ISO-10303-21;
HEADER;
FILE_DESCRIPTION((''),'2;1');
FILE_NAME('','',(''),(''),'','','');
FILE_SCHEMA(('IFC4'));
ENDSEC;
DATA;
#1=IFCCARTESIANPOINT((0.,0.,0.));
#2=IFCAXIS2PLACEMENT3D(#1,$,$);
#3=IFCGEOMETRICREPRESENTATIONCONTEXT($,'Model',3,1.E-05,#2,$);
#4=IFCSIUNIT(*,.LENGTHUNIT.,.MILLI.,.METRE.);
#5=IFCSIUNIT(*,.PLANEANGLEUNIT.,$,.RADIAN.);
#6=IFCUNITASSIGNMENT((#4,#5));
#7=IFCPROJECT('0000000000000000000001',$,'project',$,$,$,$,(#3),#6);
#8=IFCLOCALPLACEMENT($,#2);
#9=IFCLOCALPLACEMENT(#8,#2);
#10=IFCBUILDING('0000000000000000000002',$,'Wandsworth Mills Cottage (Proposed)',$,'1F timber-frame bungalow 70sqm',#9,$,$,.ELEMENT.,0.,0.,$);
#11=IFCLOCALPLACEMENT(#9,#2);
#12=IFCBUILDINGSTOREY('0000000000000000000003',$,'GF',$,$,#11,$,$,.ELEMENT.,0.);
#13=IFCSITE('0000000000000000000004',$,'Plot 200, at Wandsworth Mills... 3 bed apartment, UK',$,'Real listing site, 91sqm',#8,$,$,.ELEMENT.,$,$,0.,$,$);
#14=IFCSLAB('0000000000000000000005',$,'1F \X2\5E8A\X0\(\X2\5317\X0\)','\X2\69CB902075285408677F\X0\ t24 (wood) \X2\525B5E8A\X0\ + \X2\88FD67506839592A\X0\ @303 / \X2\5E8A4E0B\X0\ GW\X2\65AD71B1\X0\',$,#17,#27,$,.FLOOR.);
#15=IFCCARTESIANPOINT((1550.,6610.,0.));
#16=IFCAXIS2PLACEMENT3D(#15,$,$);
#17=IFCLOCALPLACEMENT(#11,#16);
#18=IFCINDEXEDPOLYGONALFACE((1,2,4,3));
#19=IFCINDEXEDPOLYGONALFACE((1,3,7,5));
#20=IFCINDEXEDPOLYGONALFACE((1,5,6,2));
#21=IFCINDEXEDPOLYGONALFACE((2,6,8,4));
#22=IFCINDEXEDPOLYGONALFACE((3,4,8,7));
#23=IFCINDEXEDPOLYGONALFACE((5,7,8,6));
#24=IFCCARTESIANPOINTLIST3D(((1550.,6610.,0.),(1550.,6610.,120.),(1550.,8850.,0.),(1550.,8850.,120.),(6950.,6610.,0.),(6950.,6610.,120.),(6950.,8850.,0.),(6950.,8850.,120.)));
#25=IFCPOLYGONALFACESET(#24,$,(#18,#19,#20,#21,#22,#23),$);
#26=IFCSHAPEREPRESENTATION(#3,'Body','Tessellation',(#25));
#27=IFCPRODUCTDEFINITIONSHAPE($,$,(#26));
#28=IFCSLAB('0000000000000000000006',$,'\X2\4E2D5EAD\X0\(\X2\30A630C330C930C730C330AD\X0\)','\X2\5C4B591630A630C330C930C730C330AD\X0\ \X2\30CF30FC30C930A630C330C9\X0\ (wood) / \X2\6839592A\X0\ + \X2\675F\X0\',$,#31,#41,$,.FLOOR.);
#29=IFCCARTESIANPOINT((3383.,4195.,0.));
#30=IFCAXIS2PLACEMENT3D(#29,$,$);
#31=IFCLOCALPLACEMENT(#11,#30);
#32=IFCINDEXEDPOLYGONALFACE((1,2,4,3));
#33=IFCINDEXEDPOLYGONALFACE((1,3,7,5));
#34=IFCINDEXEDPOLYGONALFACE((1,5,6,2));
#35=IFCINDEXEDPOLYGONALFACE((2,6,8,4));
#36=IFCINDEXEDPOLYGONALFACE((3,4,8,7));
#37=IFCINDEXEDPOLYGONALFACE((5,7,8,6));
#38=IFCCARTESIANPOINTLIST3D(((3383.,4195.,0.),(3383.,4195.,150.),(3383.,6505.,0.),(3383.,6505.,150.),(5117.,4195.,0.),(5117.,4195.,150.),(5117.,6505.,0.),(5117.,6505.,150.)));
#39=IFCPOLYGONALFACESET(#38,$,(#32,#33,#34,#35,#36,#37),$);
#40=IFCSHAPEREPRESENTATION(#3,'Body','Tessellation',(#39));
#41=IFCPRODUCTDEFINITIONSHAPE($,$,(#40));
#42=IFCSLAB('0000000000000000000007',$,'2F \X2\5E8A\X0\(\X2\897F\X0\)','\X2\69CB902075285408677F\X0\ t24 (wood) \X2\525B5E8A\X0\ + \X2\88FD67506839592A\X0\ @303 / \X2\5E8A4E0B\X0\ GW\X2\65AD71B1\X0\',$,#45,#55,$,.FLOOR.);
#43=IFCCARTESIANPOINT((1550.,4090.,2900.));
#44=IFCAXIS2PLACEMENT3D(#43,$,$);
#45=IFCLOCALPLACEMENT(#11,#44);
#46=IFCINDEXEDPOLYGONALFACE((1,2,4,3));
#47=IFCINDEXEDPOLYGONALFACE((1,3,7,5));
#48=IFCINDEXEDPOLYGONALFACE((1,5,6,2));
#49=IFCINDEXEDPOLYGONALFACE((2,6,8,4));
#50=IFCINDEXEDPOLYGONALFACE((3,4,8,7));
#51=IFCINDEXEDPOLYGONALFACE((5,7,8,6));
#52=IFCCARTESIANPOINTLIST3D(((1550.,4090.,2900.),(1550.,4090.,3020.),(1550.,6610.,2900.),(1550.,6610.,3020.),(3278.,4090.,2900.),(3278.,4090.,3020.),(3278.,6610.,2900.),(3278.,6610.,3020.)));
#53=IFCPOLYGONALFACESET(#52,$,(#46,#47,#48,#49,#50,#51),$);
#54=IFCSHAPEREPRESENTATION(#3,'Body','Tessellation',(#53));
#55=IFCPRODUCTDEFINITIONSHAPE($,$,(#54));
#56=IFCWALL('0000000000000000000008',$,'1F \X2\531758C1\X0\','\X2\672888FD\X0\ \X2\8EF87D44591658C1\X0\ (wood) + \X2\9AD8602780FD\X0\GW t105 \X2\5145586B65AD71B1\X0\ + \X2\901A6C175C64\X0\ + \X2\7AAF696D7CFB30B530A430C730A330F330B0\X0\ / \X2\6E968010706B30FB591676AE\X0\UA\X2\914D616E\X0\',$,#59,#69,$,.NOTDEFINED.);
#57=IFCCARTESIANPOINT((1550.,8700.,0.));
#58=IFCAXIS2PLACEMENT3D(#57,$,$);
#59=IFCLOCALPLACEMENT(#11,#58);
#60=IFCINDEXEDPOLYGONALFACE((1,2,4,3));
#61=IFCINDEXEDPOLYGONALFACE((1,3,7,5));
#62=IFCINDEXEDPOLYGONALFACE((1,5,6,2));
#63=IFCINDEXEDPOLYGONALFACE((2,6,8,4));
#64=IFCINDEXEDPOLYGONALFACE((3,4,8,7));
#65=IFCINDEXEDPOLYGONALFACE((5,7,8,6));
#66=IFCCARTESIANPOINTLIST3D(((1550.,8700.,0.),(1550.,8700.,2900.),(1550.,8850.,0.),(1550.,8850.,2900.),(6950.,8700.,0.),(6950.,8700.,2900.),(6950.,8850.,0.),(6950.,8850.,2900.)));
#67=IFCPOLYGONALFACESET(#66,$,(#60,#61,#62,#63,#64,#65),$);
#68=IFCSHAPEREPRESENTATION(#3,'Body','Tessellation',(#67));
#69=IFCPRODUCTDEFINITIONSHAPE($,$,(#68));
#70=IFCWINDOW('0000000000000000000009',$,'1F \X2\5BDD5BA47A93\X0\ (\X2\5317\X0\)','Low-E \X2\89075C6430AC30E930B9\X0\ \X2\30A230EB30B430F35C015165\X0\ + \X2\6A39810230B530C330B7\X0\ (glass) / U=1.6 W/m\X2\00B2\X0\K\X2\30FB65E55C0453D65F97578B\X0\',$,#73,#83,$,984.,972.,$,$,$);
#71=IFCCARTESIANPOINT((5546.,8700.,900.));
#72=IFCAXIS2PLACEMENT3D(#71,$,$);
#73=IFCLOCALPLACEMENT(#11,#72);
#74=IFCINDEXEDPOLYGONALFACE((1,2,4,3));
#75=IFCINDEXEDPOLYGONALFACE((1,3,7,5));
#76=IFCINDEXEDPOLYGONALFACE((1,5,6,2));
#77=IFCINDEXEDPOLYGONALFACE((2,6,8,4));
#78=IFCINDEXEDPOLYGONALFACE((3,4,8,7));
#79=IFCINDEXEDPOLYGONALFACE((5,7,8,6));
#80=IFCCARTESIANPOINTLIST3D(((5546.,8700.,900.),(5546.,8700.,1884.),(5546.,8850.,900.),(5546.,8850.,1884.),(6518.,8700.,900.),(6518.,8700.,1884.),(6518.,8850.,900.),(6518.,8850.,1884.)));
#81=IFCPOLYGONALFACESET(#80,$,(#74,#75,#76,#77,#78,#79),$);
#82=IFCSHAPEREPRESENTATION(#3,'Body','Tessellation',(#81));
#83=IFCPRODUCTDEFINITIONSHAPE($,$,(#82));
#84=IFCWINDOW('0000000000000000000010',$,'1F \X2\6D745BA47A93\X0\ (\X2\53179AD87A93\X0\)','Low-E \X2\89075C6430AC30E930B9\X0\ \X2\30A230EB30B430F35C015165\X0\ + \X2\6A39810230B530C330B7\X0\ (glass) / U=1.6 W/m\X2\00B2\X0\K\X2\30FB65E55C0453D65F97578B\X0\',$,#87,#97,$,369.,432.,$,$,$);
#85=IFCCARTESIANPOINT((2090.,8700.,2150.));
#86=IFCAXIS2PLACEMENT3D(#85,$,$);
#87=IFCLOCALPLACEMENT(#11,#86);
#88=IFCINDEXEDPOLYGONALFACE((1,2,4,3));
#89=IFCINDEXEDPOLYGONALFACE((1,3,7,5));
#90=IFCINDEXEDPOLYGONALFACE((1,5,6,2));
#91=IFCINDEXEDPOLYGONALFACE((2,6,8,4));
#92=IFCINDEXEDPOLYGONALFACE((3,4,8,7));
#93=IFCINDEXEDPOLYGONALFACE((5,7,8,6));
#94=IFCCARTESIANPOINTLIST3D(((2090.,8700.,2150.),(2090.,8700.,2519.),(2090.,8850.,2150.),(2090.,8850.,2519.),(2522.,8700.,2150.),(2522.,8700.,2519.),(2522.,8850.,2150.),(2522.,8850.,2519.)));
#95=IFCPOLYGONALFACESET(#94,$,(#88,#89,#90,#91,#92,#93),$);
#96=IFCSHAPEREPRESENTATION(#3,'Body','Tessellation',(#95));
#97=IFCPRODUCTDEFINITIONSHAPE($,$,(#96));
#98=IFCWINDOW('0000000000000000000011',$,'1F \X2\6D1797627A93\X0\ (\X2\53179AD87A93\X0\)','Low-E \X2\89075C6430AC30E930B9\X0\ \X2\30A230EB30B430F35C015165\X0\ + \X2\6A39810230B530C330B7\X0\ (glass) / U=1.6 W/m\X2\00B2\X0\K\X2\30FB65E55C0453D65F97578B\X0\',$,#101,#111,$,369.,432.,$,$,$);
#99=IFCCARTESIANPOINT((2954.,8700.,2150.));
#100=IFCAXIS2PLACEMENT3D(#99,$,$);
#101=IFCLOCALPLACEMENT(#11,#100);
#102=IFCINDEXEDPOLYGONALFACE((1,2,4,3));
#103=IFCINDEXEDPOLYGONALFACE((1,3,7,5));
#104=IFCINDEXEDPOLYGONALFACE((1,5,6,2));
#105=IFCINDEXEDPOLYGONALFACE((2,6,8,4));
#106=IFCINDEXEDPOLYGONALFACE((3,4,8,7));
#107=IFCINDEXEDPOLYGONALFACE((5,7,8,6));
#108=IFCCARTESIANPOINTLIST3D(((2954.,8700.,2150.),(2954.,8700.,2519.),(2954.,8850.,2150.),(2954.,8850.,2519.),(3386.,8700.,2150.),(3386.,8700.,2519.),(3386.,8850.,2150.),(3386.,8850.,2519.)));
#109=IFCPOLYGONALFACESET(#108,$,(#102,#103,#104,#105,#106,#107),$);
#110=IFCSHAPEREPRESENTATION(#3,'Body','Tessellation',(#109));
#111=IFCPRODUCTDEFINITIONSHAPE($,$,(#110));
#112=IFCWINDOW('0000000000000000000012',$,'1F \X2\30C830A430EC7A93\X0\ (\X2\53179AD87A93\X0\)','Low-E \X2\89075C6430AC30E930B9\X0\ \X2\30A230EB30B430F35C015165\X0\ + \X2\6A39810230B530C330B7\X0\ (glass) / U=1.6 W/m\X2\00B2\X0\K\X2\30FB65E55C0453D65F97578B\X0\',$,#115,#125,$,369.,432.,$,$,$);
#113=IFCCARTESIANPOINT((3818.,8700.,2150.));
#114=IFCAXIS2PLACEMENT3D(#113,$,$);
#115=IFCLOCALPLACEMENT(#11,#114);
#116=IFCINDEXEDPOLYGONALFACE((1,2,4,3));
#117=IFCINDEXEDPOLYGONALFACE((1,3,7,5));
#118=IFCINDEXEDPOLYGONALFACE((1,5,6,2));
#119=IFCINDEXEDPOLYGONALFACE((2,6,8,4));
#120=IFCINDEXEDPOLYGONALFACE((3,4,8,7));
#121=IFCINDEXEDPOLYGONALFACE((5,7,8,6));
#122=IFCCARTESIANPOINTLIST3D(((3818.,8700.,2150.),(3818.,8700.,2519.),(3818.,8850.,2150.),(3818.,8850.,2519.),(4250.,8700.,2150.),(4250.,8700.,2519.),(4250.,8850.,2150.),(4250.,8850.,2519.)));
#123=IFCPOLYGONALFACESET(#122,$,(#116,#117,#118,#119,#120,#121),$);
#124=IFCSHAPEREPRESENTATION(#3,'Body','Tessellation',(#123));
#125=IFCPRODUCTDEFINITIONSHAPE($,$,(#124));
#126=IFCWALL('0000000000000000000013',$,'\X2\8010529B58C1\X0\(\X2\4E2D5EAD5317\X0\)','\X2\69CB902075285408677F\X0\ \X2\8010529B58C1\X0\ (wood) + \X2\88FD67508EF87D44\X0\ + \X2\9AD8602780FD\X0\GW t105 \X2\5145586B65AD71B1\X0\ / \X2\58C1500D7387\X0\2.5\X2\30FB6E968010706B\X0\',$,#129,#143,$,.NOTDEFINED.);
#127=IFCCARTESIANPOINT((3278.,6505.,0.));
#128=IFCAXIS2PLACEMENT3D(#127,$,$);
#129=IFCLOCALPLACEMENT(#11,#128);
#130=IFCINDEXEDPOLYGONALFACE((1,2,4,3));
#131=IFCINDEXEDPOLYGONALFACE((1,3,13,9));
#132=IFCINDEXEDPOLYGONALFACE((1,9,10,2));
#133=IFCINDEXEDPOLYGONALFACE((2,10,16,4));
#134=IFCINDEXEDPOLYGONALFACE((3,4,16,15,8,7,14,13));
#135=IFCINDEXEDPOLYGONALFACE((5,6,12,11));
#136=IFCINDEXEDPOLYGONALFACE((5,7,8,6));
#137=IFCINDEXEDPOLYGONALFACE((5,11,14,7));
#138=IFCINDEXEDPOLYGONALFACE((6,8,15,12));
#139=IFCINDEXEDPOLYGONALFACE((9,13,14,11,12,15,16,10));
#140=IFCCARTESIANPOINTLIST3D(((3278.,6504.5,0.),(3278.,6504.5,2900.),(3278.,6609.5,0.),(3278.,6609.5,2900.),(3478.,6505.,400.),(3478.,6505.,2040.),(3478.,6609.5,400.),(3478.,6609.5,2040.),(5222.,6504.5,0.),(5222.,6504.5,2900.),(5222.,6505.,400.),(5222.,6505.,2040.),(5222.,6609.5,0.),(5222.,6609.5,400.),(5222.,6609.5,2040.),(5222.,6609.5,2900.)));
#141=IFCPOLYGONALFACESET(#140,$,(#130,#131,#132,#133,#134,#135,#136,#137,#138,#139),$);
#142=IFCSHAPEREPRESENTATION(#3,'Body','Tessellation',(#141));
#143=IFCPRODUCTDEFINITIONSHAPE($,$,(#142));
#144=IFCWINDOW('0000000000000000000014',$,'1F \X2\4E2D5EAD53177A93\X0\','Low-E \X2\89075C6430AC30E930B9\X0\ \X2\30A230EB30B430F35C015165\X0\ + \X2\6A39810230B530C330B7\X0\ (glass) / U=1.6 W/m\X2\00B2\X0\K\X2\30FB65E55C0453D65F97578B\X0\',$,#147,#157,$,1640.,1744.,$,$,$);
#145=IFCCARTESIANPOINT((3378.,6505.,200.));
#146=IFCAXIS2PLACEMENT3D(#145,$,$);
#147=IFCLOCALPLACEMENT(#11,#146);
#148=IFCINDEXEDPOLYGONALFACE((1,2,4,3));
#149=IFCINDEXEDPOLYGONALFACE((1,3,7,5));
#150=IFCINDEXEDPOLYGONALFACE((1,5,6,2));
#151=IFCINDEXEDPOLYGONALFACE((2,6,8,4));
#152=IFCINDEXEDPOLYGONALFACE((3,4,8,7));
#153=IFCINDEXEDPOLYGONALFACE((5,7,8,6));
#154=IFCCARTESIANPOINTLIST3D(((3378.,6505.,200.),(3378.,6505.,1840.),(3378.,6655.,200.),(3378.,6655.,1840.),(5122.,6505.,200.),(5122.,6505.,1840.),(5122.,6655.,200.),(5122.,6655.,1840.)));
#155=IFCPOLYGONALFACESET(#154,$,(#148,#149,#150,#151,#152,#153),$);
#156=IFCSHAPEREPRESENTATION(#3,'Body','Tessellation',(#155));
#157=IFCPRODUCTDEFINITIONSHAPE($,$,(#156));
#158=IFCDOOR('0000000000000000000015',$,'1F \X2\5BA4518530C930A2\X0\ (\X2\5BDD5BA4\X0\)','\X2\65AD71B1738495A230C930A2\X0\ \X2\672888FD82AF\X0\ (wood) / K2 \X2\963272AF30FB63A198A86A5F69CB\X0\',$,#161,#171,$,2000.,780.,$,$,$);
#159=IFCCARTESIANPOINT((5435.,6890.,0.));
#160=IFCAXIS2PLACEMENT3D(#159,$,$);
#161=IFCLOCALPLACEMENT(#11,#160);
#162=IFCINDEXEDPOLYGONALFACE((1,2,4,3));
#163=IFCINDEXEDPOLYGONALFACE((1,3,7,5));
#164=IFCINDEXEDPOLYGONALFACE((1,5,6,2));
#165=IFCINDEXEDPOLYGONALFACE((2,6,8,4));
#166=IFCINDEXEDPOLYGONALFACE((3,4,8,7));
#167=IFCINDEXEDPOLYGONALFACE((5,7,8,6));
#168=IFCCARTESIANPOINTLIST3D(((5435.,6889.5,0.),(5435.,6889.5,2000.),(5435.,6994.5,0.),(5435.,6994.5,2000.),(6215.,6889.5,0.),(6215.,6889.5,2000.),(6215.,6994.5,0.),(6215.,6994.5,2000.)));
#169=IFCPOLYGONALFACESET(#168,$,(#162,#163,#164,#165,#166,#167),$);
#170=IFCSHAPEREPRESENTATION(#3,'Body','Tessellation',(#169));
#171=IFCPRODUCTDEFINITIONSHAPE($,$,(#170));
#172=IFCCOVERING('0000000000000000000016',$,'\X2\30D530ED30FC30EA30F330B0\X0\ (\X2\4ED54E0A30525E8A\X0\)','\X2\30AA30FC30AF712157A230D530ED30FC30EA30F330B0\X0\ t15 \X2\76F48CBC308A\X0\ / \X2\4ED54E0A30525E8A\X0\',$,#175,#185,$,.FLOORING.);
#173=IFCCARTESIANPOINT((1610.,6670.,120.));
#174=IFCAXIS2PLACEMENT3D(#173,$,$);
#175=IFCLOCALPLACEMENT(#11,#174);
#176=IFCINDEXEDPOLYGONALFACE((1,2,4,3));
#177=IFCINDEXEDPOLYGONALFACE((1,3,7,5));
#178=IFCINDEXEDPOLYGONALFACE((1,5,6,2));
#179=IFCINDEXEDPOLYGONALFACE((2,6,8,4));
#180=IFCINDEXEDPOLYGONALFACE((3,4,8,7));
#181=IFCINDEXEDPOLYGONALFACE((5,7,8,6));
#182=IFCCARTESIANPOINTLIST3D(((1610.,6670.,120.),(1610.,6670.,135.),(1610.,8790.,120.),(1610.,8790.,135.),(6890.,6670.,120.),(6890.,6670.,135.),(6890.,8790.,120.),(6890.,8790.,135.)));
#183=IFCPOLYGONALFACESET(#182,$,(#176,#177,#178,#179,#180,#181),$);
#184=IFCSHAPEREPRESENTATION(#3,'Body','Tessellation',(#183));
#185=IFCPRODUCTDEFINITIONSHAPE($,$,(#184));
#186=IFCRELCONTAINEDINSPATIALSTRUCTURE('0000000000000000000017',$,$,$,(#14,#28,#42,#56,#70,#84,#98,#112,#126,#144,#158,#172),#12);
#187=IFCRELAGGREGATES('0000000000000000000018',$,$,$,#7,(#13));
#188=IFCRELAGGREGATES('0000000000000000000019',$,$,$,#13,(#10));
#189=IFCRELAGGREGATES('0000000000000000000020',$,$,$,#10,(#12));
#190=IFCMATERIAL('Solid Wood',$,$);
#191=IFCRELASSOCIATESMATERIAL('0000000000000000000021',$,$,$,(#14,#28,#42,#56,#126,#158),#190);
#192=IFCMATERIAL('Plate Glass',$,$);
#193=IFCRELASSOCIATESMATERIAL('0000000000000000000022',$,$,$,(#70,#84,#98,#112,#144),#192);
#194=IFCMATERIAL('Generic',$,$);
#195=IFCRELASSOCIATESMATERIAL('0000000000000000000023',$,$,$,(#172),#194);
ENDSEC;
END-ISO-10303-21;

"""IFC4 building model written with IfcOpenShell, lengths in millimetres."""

from ifc_helpers import new_model, si_unit, frame, frame_2d, origin, place, context, project, spatial, rectangle, extrude, material, element, fill, save


model = new_model("IFC4")

# Units and contexts
model_context = context("Model", 3, precision=1e-05, world=origin())
ifc_project = project(units=[si_unit("LENGTHUNIT", "METRE", prefix="MILLI"), si_unit("PLANEANGLEUNIT", "RADIAN")], contexts=[model_context])

# Site, building, storey
site_placement = place(None, origin())
site = spatial("IfcSite", under=ifc_project, at=site_placement, Name="Plot 200, at Wandsworth Mills... 3 bed apartment, UK", ObjectType="Real listing site, 91sqm", CompositionType="ELEMENT", RefElevation=0.0)
building_placement = place(site_placement, origin())
building = spatial("IfcBuilding", under=site, at=building_placement, Name="Wandsworth Mills Cottage (Proposed)", ObjectType="1F timber-frame bungalow 70sqm", CompositionType="ELEMENT", ElevationOfRefHeight=0.0, ElevationOfTerrain=0.0)
storey_placement = place(building_placement, origin())
storey = spatial("IfcBuildingStorey", under=building, at=storey_placement, Name="GF", CompositionType="ELEMENT", Elevation=0.0)

# Slabs
ifc_material_1 = material(Name="Solid Wood")
slab_1_placement = place(storey_placement, frame((1550.0, 6610.0, 0.0)))
element("IfcSlab", 1, at=slab_1_placement, inside=storey, material=ifc_material_1, Name="1F 床(北)", Description="構造用合板 t24 (wood) 剛床 + 製材根太 @303 / 床下 GW断熱", PredefinedType="FLOOR", context=model_context, shape_type="SweptSolid", body=[
    extrude(rectangle(XDim=5400.0, YDim=2240.0, at=frame_2d((2700.0, 1120.0))), frame((1550.0, 6610.0, 0.0)), (0.0, 0.0, 1.0), 120.0),
])
slab_2_placement = place(storey_placement, frame((3383.0, 4195.0, 0.0)))
element("IfcSlab", 2, at=slab_2_placement, inside=storey, material=ifc_material_1, Name="中庭(ウッドデッキ)", Description="屋外ウッドデッキ ハードウッド (wood) / 根太 + 束", PredefinedType="FLOOR", context=model_context, shape_type="SweptSolid", body=[
    extrude(rectangle(XDim=1734.0, YDim=2310.0, at=frame_2d((867.0, 1155.0))), frame((3383.0, 4195.0, 0.0)), (0.0, 0.0, 1.0), 150.0),
])
slab_3_placement = place(storey_placement, frame((1550.0, 4090.0, 2900.0)))
element("IfcSlab", 3, at=slab_3_placement, inside=storey, material=ifc_material_1, Name="2F 床(西)", Description="構造用合板 t24 (wood) 剛床 + 製材根太 @303 / 床下 GW断熱", PredefinedType="FLOOR", context=model_context, shape_type="SweptSolid", body=[
    extrude(rectangle(XDim=1728.0, YDim=2520.0, at=frame_2d((864.0, 1260.0))), frame((1550.0, 4090.0, 2900.0)), (0.0, 0.0, 1.0), 120.0),
])

# Wall, openings, windows
wall_1_placement = place(storey_placement, frame((1550.0, 8700.0, 0.0)))
wall_1 = element("IfcWall", 4, at=wall_1_placement, inside=storey, material=ifc_material_1, Name="1F 北壁", Description="木製 軸組外壁 (wood) + 高性能GW t105 充填断熱 + 通気層 + 窯業系サイディング / 準耐火・外皮UA配慮", PredefinedType="NOTDEFINED", context=model_context, shape_type="SweptSolid", body=[
    extrude(rectangle(XDim=5400.0, YDim=150.0, at=frame_2d((2700.0, 75.0))), frame((1550.0, 8700.0, 0.0)), (0.0, 0.0, 1.0), 2900.0),
])
opening_1_placement = place(storey_placement, frame((5546.0, 8700.0, 900.0)))
opening_1 = element("IfcOpeningElement", 5, at=opening_1_placement, cuts=wall_1, PredefinedType="NOTDEFINED", context=model_context, shape_type="SweptSolid", body=[
    extrude(rectangle(XDim=972.0, YDim=150.0, at=frame_2d((486.0, 75.0))), frame((5546.0, 8700.0, 900.0)), (0.0, 0.0, 1.0), 984.0),
])
opening_2_placement = place(storey_placement, frame((2090.0, 8700.0, 2150.0)))
opening_2 = element("IfcOpeningElement", 6, at=opening_2_placement, cuts=wall_1, PredefinedType="NOTDEFINED", context=model_context, shape_type="SweptSolid", body=[
    extrude(rectangle(XDim=432.0, YDim=150.0, at=frame_2d((216.0, 75.0))), frame((2090.0, 8700.0, 2150.0)), (0.0, 0.0, 1.0), 369.0),
])
opening_3_placement = place(storey_placement, frame((2954.0, 8700.0, 2150.0)))
opening_3 = element("IfcOpeningElement", 7, at=opening_3_placement, cuts=wall_1, PredefinedType="NOTDEFINED", context=model_context, shape_type="SweptSolid", body=[
    extrude(rectangle(XDim=432.0, YDim=150.0, at=frame_2d((216.0, 75.0))), frame((2954.0, 8700.0, 2150.0)), (0.0, 0.0, 1.0), 369.0),
])
opening_4_placement = place(storey_placement, frame((3818.0, 8700.0, 2150.0)))
opening_4 = element("IfcOpeningElement", 8, at=opening_4_placement, cuts=wall_1, PredefinedType="NOTDEFINED", context=model_context, shape_type="SweptSolid", body=[
    extrude(rectangle(XDim=432.0, YDim=150.0, at=frame_2d((216.0, 75.0))), frame((3818.0, 8700.0, 2150.0)), (0.0, 0.0, 1.0), 369.0),
])
ifc_material_2 = material(Name="Plate Glass")
window_1_placement = place(storey_placement, frame((5546.0, 8700.0, 900.0)))
window_1 = element("IfcWindow", 9, at=window_1_placement, inside=storey, material=ifc_material_2, Name="1F 寝室窓 (北)", Description="Low-E 複層ガラス アルゴン封入 + 樹脂サッシ (glass) / U=1.6 W/m²K・日射取得型", OverallHeight=984.0, OverallWidth=972.0, context=model_context, shape_type="SweptSolid", body=[
    extrude(rectangle(XDim=972.0, YDim=150.0, at=frame_2d((486.0, 75.0))), frame((5546.0, 8700.0, 900.0)), (0.0, 0.0, 1.0), 984.0),
])
fill(opening_1, window_1)
window_2_placement = place(storey_placement, frame((2090.0, 8700.0, 2150.0)))
window_2 = element("IfcWindow", 10, at=window_2_placement, inside=storey, material=ifc_material_2, Name="1F 浴室窓 (北高窓)", Description="Low-E 複層ガラス アルゴン封入 + 樹脂サッシ (glass) / U=1.6 W/m²K・日射取得型", OverallHeight=369.0, OverallWidth=432.0, context=model_context, shape_type="SweptSolid", body=[
    extrude(rectangle(XDim=432.0, YDim=150.0, at=frame_2d((216.0, 75.0))), frame((2090.0, 8700.0, 2150.0)), (0.0, 0.0, 1.0), 369.0),
])
fill(opening_2, window_2)
window_3_placement = place(storey_placement, frame((2954.0, 8700.0, 2150.0)))
window_3 = element("IfcWindow", 11, at=window_3_placement, inside=storey, material=ifc_material_2, Name="1F 洗面窓 (北高窓)", Description="Low-E 複層ガラス アルゴン封入 + 樹脂サッシ (glass) / U=1.6 W/m²K・日射取得型", OverallHeight=369.0, OverallWidth=432.0, context=model_context, shape_type="SweptSolid", body=[
    extrude(rectangle(XDim=432.0, YDim=150.0, at=frame_2d((216.0, 75.0))), frame((2954.0, 8700.0, 2150.0)), (0.0, 0.0, 1.0), 369.0),
])
fill(opening_3, window_3)
window_4_placement = place(storey_placement, frame((3818.0, 8700.0, 2150.0)))
window_4 = element("IfcWindow", 12, at=window_4_placement, inside=storey, material=ifc_material_2, Name="1F トイレ窓 (北高窓)", Description="Low-E 複層ガラス アルゴン封入 + 樹脂サッシ (glass) / U=1.6 W/m²K・日射取得型", OverallHeight=369.0, OverallWidth=432.0, context=model_context, shape_type="SweptSolid", body=[
    extrude(rectangle(XDim=432.0, YDim=150.0, at=frame_2d((216.0, 75.0))), frame((3818.0, 8700.0, 2150.0)), (0.0, 0.0, 1.0), 369.0),
])
fill(opening_4, window_4)

# Wall, opening, window
wall_2_placement = place(storey_placement, frame((3278.0, 6505.0, 0.0)))
wall_2 = element("IfcWall", 13, at=wall_2_placement, inside=storey, material=ifc_material_1, Name="耐力壁(中庭北)", Description="構造用合板 耐力壁 (wood) + 製材軸組 + 高性能GW t105 充填断熱 / 壁倍率2.5・準耐火", PredefinedType="NOTDEFINED", context=model_context, shape_type="SweptSolid", body=[
    extrude(rectangle(XDim=1944.0, YDim=105.0, at=frame_2d((972.0, 52.0))), frame((3278.0, 6505.0, 0.0)), (0.0, 0.0, 1.0), 2900.0),
])
opening_5_placement = place(storey_placement, frame((3378.0, 6505.0, 200.0)))
opening_5 = element("IfcOpeningElement", 14, at=opening_5_placement, cuts=wall_2, PredefinedType="NOTDEFINED", context=model_context, shape_type="SweptSolid", body=[
    extrude(rectangle(XDim=1744.0, YDim=150.0, at=frame_2d((872.0, 75.0))), frame((3378.0, 6505.0, 200.0)), (0.0, 0.0, 1.0), 1640.0),
])
window_5_placement = place(storey_placement, frame((3378.0, 6505.0, 200.0)))
window_5 = element("IfcWindow", 15, at=window_5_placement, inside=storey, material=ifc_material_2, Name="1F 中庭北窓", Description="Low-E 複層ガラス アルゴン封入 + 樹脂サッシ (glass) / U=1.6 W/m²K・日射取得型", OverallHeight=1640.0, OverallWidth=1744.0, context=model_context, shape_type="SweptSolid", body=[
    extrude(rectangle(XDim=1744.0, YDim=150.0, at=frame_2d((872.0, 75.0))), frame((3378.0, 6505.0, 200.0)), (0.0, 0.0, 1.0), 1640.0),
])
fill(opening_5, window_5)

# Door
door_1_placement = place(storey_placement, frame((5435.0, 6890.0, 0.0)))
element("IfcDoor", 16, at=door_1_placement, inside=storey, material=ifc_material_1, Name="1F 室内ドア (寝室)", Description="断熱玄関ドア 木製芯 (wood) / K2 防犯・採風機構", OverallHeight=2000.0, OverallWidth=780.0, context=model_context, shape_type="SweptSolid", body=[
    extrude(rectangle(XDim=780.0, YDim=105.0, at=frame_2d((390.0, 52.0))), frame((5435.0, 6890.0, 0.0)), (0.0, 0.0, 1.0), 2000.0),
])

# Covering
ifc_material_3 = material(Name="Generic")
covering_1_placement = place(storey_placement, frame((1610.0, 6670.0, 120.0)))
element("IfcCovering", 17, at=covering_1_placement, inside=storey, material=ifc_material_3, Name="フローリング (仕上げ床)", Description="オーク無垢フローリング t15 直貼り / 仕上げ床", PredefinedType="FLOORING", context=model_context, shape_type="SweptSolid", body=[
    extrude(rectangle(XDim=5280.0, YDim=2120.0, at=frame_2d((2640.0, 1060.0))), frame((1610.0, 6670.0, 120.0)), (0.0, 0.0, 1.0), 15.0),
])

save(model, "model.ifc")
